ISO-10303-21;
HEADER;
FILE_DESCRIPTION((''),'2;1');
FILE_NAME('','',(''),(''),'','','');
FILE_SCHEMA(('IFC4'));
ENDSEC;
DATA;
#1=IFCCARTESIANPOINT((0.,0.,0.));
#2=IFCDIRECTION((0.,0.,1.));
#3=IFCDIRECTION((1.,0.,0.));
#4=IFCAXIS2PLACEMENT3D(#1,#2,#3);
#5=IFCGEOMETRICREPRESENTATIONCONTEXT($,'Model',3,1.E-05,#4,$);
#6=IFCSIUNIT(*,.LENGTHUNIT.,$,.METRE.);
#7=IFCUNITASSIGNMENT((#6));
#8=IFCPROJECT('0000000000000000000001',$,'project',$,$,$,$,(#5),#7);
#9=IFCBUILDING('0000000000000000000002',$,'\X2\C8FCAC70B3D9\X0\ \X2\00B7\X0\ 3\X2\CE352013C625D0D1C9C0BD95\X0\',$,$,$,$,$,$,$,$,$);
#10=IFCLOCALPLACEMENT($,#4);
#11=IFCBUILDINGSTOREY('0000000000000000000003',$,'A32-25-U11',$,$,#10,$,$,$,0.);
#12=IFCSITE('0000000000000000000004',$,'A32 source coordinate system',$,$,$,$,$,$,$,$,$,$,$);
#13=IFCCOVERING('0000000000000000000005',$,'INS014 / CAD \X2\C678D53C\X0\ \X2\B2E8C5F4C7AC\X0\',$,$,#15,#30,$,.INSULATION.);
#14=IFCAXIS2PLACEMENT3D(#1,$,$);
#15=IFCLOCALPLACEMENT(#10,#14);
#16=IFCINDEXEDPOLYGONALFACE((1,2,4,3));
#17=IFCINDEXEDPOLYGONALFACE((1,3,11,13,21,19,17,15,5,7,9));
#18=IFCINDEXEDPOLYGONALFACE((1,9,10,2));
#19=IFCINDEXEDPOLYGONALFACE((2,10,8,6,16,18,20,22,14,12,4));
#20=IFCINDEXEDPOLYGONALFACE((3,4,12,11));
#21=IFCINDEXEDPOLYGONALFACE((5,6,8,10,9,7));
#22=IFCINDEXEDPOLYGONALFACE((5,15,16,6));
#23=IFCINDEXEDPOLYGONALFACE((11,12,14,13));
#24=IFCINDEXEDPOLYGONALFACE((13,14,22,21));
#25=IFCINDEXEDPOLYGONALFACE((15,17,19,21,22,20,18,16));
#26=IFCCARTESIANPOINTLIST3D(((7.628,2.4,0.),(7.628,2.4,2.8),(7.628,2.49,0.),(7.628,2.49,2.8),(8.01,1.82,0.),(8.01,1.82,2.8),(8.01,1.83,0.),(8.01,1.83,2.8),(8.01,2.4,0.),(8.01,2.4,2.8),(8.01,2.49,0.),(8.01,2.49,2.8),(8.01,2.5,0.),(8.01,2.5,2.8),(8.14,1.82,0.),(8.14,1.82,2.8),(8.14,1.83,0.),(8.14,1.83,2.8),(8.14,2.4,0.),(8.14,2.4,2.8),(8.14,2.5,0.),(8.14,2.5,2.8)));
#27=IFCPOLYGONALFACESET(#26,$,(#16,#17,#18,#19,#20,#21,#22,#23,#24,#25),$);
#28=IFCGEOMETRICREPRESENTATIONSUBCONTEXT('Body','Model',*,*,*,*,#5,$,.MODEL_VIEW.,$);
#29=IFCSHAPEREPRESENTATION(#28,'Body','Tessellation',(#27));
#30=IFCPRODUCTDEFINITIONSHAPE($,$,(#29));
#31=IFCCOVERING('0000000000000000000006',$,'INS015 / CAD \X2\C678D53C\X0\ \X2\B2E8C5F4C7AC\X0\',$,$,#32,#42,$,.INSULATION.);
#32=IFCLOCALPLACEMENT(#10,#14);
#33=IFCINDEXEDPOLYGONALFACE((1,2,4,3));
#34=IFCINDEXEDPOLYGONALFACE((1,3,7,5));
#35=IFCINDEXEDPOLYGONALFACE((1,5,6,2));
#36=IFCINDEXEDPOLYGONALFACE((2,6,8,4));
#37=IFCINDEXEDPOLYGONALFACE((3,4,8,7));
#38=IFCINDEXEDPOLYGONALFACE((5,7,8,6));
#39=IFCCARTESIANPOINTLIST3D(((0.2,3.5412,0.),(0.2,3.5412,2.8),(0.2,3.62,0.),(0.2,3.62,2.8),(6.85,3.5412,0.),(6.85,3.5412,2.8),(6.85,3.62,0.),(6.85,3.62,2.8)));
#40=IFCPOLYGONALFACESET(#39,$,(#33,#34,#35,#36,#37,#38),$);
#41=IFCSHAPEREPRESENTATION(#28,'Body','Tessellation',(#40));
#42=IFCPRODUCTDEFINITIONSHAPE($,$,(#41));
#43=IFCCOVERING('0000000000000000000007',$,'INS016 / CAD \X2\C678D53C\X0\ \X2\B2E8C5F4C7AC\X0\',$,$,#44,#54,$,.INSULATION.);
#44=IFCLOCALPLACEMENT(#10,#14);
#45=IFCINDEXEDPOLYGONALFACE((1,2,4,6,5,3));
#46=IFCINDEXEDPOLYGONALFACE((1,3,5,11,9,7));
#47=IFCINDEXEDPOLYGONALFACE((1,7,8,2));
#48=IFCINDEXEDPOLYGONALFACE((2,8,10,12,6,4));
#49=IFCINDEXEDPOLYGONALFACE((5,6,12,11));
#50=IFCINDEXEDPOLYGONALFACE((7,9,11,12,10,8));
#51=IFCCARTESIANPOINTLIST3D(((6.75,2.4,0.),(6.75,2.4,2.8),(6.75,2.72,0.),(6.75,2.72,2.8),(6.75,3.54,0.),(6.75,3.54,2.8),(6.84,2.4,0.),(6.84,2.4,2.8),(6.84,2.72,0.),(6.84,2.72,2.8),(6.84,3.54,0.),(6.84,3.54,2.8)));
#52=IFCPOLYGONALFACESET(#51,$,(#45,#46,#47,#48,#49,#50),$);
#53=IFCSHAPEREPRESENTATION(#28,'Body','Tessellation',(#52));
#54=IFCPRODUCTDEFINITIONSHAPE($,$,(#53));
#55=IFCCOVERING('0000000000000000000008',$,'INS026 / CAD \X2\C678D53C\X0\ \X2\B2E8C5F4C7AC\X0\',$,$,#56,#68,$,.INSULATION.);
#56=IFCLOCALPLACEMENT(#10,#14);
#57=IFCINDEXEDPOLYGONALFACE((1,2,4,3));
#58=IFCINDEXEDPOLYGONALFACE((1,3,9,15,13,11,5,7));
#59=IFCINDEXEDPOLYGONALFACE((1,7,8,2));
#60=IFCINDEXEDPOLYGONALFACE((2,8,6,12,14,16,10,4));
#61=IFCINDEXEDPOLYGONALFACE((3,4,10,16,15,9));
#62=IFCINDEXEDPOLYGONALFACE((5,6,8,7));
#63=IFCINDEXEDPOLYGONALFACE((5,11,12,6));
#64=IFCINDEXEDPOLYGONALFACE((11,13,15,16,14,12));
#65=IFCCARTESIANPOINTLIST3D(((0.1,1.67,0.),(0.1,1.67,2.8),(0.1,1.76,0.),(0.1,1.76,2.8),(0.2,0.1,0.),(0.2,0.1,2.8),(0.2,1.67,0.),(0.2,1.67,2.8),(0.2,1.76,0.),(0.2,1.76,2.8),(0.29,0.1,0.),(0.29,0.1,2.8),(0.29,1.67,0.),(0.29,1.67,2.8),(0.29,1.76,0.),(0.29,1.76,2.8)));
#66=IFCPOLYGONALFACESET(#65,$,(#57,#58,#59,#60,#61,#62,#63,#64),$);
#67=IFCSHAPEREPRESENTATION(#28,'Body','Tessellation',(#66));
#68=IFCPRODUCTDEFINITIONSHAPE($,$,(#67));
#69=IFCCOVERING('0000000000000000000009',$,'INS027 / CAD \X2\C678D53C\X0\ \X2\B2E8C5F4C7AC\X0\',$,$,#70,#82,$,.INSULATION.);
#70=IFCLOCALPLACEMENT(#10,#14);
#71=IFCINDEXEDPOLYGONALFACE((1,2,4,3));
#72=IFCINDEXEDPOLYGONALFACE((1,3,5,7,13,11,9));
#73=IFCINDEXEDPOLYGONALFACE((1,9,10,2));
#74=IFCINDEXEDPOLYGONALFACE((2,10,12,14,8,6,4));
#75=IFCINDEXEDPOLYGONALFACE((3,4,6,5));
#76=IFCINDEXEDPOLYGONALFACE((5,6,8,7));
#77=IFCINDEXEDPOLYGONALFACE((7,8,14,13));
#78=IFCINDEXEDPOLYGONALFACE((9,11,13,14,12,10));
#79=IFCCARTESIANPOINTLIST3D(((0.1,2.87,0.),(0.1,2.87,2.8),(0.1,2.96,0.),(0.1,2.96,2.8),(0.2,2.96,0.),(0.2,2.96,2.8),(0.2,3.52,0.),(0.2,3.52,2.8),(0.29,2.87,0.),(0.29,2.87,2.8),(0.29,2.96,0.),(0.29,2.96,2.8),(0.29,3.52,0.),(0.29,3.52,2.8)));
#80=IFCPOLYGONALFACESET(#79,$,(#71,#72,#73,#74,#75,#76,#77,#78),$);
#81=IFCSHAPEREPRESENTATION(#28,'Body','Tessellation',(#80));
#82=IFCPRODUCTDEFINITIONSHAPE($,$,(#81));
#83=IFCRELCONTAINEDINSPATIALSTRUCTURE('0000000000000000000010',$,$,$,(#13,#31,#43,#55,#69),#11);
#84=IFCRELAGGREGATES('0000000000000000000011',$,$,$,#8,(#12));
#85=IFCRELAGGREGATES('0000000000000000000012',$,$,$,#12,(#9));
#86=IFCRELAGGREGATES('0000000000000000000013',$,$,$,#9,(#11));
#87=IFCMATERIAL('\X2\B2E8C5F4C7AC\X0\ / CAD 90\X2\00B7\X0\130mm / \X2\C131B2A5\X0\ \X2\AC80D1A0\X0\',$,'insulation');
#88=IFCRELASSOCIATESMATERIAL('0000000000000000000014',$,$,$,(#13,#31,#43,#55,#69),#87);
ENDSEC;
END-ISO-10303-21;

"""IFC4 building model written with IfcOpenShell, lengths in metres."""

from ifc_helpers import new_model, si_unit, origin, origin_with_axes, place, context, subcontext, project, spatial, polyline, outline, extrude, material, element, save


model = new_model("IFC4")

# Units and contexts
model_context = context("Model", 3, precision=1e-05, world=origin_with_axes())
body_context = subcontext(model_context, "Body", "Model", "MODEL_VIEW")
ifc_project = project(units=[si_unit("LENGTHUNIT", "METRE")], contexts=[model_context])

# Site, building, storey
storey_placement = place(None, origin_with_axes())
site = spatial("IfcSite", under=ifc_project, Name="A32 source coordinate system")
building = spatial("IfcBuilding", under=site, Name="주거동 · 3층–옥탑지붕")
storey = spatial("IfcBuildingStorey", under=building, at=storey_placement, Name="A32-25-U11", Elevation=0.0)

# Coverings
ifc_material = material(Name="단열재 / CAD 90·130mm / 성능 검토", Category="insulation")
covering_1_placement = place(storey_placement, origin_with_axes())
element("IfcCovering", 1, at=covering_1_placement, inside=storey, material=ifc_material, Name="INS014 / CAD 외피 단열재", PredefinedType="INSULATION", context=body_context, shape_type="SweptSolid", body=[
    extrude(outline(polyline([(8.14, 2.5), (8.14, 2.4), (8.14, 1.83), (8.14, 1.82), (8.01, 1.82), (8.01, 1.83), (8.01, 2.4), (7.628, 2.4), (7.628, 2.49), (8.01, 2.49), (8.01, 2.5), (8.14, 2.5)])), origin(), (0.0, 0.0, 1.0), 2.8),
])
covering_2_placement = place(storey_placement, origin_with_axes())
element("IfcCovering", 2, at=covering_2_placement, inside=storey, material=ifc_material, Name="INS015 / CAD 외피 단열재", PredefinedType="INSULATION", context=body_context, shape_type="SweptSolid", body=[
    extrude(outline(polyline([(0.2, 3.5412), (0.2, 3.62), (6.85, 3.62), (6.85, 3.5412), (0.2, 3.5412)])), origin(), (0.0, 0.0, 1.0), 2.8),
])
covering_3_placement = place(storey_placement, origin_with_axes())
element("IfcCovering", 3, at=covering_3_placement, inside=storey, material=ifc_material, Name="INS016 / CAD 외피 단열재", PredefinedType="INSULATION", context=body_context, shape_type="SweptSolid", body=[
    extrude(outline(polyline([(6.84, 2.72), (6.84, 2.4), (6.75, 2.4), (6.75, 2.72), (6.75, 3.54), (6.84, 3.54), (6.84, 2.72)])), origin(), (0.0, 0.0, 1.0), 2.8),
])
covering_4_placement = place(storey_placement, origin_with_axes())
element("IfcCovering", 4, at=covering_4_placement, inside=storey, material=ifc_material, Name="INS026 / CAD 외피 단열재", PredefinedType="INSULATION", context=body_context, shape_type="SweptSolid", body=[
    extrude(outline(polyline([(0.2, 1.76), (0.29, 1.76), (0.29, 1.67), (0.29, 0.1), (0.2, 0.1), (0.2, 1.67), (0.1, 1.67), (0.1, 1.76), (0.2, 1.76)])), origin(), (0.0, 0.0, 1.0), 2.8),
])
covering_5_placement = place(storey_placement, origin_with_axes())
element("IfcCovering", 5, at=covering_5_placement, inside=storey, material=ifc_material, Name="INS027 / CAD 외피 단열재", PredefinedType="INSULATION", context=body_context, shape_type="SweptSolid", body=[
    extrude(outline(polyline([(0.2, 3.52), (0.29, 3.52), (0.29, 2.96), (0.29, 2.87), (0.1, 2.87), (0.1, 2.96), (0.2, 2.96), (0.2, 3.52)])), origin(), (0.0, 0.0, 1.0), 2.8),
])

save(model, "model.ifc")
